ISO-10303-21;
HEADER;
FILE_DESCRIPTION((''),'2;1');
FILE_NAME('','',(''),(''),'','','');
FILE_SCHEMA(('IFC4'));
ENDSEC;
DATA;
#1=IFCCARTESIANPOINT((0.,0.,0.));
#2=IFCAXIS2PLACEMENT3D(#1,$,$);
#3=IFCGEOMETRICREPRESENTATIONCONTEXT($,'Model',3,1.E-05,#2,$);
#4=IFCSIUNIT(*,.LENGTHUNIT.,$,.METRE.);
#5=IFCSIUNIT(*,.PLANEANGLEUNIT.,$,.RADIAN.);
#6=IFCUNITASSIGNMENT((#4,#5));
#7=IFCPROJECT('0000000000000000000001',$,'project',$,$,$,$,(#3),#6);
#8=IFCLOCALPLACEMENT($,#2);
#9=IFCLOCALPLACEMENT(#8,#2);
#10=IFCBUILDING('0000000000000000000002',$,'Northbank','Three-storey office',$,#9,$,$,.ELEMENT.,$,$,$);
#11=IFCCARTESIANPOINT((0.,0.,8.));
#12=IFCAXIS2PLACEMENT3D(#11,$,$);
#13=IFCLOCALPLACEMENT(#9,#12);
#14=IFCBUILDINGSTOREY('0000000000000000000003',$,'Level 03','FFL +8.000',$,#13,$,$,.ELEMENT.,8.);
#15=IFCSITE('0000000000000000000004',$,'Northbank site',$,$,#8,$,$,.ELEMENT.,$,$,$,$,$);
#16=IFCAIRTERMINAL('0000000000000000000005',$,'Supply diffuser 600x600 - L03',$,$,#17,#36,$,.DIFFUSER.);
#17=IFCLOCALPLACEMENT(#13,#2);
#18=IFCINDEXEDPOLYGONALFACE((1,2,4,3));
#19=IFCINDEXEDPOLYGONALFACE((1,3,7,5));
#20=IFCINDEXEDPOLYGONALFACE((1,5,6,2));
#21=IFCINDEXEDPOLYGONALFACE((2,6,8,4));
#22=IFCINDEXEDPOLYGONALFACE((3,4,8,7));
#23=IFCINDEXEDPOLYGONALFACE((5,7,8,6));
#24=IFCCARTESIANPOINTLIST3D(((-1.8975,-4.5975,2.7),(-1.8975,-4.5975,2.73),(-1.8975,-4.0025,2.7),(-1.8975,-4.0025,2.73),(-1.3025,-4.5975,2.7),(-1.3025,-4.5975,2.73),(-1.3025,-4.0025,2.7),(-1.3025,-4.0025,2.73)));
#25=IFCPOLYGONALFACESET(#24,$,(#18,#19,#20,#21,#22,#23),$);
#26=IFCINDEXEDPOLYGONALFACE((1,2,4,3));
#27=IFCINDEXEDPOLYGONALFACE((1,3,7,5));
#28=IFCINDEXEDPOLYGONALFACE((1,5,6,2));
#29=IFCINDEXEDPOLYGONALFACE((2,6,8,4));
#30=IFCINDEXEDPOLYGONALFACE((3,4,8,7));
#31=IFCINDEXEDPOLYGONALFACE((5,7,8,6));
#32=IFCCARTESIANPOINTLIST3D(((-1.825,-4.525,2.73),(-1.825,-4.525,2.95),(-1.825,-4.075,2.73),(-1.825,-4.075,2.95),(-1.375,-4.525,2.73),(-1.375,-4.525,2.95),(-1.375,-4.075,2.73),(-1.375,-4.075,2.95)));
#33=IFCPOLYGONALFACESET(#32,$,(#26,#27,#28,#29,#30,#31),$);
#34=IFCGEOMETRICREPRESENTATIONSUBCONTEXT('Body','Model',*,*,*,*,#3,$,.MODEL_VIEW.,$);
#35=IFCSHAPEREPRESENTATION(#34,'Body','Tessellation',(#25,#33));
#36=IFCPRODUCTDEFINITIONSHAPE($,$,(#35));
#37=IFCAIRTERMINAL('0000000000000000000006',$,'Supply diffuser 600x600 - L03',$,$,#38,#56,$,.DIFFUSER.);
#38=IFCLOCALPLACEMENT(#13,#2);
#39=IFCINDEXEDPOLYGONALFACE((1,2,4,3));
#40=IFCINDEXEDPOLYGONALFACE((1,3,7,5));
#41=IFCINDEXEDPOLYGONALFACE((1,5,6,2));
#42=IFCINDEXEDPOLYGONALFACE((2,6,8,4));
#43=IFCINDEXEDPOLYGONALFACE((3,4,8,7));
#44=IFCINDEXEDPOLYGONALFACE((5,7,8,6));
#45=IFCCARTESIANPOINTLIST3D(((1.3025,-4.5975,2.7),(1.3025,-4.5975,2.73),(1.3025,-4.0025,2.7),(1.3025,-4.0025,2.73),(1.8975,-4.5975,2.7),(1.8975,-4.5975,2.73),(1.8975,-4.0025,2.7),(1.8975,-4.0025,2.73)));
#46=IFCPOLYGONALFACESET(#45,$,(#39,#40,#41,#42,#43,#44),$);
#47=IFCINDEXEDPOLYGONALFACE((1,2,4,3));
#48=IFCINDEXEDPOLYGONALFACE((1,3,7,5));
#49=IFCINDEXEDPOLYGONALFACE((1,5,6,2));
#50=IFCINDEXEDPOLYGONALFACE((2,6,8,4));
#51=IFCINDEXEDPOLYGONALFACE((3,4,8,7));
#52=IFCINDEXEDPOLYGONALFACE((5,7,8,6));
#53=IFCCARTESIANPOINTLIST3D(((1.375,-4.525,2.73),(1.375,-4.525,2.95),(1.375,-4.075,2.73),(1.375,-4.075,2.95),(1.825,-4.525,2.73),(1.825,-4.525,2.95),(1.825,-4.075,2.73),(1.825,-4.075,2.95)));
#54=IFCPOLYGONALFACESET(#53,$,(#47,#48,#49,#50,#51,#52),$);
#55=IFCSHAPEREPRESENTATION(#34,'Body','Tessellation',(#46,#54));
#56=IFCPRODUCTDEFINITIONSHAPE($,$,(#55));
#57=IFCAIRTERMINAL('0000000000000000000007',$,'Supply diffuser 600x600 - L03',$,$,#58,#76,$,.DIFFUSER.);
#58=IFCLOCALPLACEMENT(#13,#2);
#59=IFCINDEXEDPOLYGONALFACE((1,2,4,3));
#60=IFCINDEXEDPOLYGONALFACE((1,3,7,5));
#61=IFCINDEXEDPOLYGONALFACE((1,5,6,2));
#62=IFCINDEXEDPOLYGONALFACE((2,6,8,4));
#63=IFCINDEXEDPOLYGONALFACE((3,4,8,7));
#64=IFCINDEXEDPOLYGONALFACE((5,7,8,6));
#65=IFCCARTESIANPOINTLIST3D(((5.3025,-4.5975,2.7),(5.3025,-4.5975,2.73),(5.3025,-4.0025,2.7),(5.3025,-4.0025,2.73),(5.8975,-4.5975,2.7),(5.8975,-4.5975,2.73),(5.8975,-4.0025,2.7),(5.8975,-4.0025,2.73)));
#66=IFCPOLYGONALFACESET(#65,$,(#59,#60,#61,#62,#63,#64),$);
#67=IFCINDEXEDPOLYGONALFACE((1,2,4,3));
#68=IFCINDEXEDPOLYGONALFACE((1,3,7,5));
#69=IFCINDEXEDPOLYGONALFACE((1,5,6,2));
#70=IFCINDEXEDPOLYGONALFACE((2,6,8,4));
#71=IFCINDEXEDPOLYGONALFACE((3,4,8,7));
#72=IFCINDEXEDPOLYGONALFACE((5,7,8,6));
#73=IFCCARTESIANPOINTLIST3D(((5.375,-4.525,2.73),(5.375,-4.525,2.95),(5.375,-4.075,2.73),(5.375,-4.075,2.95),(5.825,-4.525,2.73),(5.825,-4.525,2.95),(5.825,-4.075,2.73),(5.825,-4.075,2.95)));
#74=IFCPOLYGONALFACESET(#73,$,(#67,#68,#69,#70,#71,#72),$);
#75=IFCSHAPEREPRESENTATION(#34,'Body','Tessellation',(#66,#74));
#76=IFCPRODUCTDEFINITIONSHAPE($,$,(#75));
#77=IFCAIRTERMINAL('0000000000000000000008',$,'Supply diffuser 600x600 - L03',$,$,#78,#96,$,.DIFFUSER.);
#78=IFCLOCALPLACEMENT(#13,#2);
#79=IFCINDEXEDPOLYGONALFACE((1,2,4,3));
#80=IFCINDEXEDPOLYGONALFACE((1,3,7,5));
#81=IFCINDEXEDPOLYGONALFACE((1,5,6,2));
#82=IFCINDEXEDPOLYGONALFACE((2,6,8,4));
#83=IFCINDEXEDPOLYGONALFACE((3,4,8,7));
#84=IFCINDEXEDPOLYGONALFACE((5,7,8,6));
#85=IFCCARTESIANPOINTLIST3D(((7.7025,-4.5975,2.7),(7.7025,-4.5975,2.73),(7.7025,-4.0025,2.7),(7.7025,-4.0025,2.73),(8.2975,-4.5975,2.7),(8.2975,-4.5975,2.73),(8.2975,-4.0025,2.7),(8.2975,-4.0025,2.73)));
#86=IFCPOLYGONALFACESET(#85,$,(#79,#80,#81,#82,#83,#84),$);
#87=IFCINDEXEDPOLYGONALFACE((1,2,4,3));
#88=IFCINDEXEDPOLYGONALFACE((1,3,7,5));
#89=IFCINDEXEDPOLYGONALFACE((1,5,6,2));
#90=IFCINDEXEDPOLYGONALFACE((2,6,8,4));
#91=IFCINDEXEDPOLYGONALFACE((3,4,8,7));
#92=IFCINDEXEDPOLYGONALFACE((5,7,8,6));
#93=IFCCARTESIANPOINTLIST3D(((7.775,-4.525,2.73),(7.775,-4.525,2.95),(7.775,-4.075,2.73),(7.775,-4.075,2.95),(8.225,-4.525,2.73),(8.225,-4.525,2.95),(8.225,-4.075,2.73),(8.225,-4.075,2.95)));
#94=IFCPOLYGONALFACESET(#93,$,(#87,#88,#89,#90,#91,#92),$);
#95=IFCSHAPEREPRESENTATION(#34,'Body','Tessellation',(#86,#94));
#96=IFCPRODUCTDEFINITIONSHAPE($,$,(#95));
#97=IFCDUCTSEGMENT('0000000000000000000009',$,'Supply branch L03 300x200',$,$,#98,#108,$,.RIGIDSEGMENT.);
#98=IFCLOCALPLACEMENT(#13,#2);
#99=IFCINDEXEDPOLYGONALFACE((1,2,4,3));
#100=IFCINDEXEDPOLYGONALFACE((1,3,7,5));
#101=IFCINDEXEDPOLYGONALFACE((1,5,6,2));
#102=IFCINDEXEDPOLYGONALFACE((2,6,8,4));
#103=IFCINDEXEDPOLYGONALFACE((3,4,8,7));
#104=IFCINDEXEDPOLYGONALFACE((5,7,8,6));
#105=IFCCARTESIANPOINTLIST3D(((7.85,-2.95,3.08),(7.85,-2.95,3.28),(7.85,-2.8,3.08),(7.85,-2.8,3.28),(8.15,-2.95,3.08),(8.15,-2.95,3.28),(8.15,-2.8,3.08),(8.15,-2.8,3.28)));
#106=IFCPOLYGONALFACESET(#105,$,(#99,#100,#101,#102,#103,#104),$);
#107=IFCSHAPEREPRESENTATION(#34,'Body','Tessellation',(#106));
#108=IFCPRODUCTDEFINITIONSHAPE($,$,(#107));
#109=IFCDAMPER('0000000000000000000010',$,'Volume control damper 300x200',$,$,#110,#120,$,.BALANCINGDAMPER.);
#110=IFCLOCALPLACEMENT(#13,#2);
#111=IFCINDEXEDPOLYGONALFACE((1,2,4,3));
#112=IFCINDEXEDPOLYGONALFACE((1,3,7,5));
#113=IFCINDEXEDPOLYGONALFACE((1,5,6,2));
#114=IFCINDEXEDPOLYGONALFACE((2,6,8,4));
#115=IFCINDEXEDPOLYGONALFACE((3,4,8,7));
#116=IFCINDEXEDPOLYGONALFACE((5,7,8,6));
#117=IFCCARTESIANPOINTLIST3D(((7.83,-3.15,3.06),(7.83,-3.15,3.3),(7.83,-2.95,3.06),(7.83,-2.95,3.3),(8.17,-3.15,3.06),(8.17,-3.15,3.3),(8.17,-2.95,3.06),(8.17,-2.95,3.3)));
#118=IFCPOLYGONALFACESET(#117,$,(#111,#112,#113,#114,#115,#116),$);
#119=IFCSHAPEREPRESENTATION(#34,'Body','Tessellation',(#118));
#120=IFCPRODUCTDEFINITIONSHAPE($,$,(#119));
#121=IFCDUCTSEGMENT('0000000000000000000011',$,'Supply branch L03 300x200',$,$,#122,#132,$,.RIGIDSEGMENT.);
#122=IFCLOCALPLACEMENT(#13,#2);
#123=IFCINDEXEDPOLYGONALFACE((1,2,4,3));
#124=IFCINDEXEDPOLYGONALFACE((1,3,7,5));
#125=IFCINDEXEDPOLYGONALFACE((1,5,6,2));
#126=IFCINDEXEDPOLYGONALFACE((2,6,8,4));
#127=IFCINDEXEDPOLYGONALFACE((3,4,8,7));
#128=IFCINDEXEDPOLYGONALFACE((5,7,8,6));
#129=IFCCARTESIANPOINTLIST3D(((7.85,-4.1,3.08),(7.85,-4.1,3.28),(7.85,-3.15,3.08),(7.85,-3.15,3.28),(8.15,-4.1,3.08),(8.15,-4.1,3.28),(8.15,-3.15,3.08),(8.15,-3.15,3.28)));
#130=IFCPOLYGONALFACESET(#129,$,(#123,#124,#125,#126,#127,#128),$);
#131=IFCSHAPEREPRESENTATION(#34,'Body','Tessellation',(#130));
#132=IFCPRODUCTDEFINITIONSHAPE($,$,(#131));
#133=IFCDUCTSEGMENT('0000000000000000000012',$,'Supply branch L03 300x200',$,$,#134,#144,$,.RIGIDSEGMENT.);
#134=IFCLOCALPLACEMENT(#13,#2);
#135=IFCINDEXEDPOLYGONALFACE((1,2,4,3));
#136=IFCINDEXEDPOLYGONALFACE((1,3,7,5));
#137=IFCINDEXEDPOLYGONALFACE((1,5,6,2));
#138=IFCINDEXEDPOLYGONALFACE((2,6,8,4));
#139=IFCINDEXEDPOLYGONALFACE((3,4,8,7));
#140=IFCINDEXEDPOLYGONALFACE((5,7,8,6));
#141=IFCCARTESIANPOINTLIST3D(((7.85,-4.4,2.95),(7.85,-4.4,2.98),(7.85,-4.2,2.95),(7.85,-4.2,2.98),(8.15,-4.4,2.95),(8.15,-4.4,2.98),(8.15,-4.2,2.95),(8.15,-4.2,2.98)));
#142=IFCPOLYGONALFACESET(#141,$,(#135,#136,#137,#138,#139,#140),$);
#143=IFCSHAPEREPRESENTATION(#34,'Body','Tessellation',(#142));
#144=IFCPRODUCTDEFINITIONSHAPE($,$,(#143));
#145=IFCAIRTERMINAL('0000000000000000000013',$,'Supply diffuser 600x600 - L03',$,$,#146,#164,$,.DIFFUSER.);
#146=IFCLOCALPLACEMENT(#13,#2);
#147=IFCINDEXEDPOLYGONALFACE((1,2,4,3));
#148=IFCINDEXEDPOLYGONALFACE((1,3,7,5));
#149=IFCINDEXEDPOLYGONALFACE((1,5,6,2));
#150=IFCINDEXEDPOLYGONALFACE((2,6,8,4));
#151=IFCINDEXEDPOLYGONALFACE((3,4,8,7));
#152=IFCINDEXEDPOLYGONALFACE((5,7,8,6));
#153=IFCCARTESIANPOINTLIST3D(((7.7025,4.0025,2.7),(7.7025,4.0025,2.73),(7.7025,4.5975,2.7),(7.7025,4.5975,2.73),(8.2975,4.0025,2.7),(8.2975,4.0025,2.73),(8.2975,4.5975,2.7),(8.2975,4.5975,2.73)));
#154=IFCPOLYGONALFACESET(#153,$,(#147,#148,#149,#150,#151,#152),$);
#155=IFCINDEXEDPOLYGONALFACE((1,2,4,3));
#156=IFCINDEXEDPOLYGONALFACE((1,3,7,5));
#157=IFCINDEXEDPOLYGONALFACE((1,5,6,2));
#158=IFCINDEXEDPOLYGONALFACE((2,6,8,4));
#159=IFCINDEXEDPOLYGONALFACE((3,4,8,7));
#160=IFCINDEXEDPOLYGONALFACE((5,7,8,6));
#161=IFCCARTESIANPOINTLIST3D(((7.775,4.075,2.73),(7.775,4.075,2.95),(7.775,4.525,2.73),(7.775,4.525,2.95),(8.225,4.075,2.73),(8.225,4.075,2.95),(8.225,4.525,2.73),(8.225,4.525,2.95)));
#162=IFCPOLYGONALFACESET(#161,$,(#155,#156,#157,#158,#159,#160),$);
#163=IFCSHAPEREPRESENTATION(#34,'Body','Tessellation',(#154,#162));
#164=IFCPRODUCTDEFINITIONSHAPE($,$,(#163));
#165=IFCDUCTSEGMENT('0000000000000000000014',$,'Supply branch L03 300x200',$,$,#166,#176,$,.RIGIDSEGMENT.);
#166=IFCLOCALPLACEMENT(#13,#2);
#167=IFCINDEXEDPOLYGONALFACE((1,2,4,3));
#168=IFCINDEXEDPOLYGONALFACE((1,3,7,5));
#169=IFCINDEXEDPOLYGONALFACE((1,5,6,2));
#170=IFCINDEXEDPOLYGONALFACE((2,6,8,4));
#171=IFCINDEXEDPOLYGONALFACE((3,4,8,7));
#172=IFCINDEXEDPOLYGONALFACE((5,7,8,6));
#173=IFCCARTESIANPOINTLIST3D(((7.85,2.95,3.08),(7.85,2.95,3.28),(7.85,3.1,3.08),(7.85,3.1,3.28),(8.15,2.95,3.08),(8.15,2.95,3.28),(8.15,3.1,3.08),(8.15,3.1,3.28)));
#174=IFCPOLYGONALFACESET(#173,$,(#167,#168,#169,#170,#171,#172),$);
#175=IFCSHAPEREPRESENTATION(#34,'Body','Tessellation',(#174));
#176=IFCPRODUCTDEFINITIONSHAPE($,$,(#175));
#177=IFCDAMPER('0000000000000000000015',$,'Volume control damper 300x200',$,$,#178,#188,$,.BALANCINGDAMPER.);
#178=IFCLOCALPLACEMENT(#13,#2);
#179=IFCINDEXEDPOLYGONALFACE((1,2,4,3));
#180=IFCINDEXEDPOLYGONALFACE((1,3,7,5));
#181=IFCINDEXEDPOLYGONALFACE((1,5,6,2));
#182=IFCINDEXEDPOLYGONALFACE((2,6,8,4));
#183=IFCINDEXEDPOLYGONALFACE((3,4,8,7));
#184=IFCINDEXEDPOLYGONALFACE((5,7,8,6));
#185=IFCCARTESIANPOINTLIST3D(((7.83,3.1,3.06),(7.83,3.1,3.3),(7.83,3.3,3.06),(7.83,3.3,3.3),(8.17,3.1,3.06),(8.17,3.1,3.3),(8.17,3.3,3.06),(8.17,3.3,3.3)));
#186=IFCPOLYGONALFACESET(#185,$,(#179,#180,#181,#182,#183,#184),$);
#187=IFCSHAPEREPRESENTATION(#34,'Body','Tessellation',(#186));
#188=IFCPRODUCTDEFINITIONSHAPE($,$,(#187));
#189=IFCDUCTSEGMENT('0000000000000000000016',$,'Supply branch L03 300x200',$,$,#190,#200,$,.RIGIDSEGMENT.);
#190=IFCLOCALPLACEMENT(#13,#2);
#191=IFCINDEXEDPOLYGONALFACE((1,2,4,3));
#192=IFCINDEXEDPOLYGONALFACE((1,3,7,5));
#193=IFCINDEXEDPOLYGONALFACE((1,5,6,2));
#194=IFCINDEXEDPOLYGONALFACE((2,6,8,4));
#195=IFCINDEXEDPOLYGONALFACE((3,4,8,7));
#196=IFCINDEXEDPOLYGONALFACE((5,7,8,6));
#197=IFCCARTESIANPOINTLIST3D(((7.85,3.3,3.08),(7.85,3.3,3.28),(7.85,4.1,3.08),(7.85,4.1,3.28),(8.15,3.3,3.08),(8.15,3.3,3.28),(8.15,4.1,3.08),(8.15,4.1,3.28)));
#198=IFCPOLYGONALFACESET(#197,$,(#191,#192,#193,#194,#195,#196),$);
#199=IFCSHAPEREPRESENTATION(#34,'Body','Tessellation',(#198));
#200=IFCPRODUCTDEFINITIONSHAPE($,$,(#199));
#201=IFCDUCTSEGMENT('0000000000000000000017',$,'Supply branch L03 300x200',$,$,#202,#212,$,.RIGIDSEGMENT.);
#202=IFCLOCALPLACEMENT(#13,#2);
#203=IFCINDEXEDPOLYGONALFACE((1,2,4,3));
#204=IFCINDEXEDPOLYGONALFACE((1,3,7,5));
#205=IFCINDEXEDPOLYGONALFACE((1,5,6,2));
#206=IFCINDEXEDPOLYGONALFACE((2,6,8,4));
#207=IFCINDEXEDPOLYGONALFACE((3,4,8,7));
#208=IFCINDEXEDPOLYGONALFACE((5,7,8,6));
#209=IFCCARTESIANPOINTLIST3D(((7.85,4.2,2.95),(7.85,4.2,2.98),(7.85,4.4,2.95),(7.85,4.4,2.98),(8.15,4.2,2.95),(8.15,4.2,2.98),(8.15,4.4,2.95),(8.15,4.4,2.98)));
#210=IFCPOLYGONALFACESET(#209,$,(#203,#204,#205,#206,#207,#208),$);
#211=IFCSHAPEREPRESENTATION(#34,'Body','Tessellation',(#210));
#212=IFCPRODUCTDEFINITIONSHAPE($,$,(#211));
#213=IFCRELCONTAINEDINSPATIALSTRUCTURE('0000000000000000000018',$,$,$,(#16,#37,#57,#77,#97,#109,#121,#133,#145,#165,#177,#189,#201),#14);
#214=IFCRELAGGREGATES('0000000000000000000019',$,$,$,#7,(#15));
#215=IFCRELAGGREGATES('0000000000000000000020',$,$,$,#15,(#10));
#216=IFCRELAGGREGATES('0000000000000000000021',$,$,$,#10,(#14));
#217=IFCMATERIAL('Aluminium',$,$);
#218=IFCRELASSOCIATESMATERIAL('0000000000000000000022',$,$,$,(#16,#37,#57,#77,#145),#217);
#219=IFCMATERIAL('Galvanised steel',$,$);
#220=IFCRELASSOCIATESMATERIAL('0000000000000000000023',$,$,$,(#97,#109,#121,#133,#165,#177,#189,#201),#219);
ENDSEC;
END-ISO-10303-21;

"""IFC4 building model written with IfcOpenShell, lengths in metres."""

from ifc_helpers import new_model, si_unit, frame, origin, place, context, subcontext, project, spatial, rectangle, extrude, material, element, save


model = new_model("IFC4")

# Units and contexts
model_context = context("Model", 3, precision=1e-05, world=origin())
body_context = subcontext(model_context, "Body", "Model", "MODEL_VIEW")
ifc_project = project(units=[si_unit("LENGTHUNIT", "METRE"), si_unit("PLANEANGLEUNIT", "RADIAN")], contexts=[model_context])

# Site, building, storey
site_placement = place(None, origin())
site = spatial("IfcSite", under=ifc_project, at=site_placement, Name="Northbank site", CompositionType="ELEMENT")
building_placement = place(site_placement, origin())
building = spatial("IfcBuilding", under=site, at=building_placement, Name="Northbank", Description="Three-storey office", CompositionType="ELEMENT")
storey_placement = place(building_placement, frame((0.0, 0.0, 8.0)))
storey = spatial("IfcBuildingStorey", under=building, at=storey_placement, Name="Level 03", Description="FFL +8.000", CompositionType="ELEMENT", Elevation=8.0)

# Shared definitions
ifc_material_1 = material(Name="Galvanised steel")

# Air terminal
ifc_material_2 = material(Name="Aluminium")
air_terminal_1_placement = place(storey_placement, frame((0.0, 0.0, -8.0)))
element("IfcAirTerminal", 1, at=air_terminal_1_placement, inside=storey, material=ifc_material_2, Name="Supply diffuser 600x600 - L03", PredefinedType="DIFFUSER", context=body_context, shape_type="SweptSolid", body=[
    extrude(rectangle(XDim=0.595, YDim=0.595), frame((-1.6, -4.3, 10.7)), (0.0, 0.0, 1.0), 0.03),
    extrude(rectangle(XDim=0.45, YDim=0.45), frame((-1.6, -4.3, 10.73)), (0.0, 0.0, 1.0), 0.22),
])

# Air terminal
air_terminal_2_placement = place(storey_placement, frame((0.0, 0.0, -8.0)))
element("IfcAirTerminal", 2, at=air_terminal_2_placement, inside=storey, material=ifc_material_2, Name="Supply diffuser 600x600 - L03", PredefinedType="DIFFUSER", context=body_context, shape_type="SweptSolid", body=[
    extrude(rectangle(XDim=0.595, YDim=0.595), frame((1.6, -4.3, 10.7)), (0.0, 0.0, 1.0), 0.03),
    extrude(rectangle(XDim=0.45, YDim=0.45), frame((1.6, -4.3, 10.73)), (0.0, 0.0, 1.0), 0.22),
])

# Air terminal
air_terminal_3_placement = place(storey_placement, frame((0.0, 0.0, -8.0)))
element("IfcAirTerminal", 3, at=air_terminal_3_placement, inside=storey, material=ifc_material_2, Name="Supply diffuser 600x600 - L03", PredefinedType="DIFFUSER", context=body_context, shape_type="SweptSolid", body=[
    extrude(rectangle(XDim=0.595, YDim=0.595), frame((5.6, -4.3, 10.7)), (0.0, 0.0, 1.0), 0.03),
    extrude(rectangle(XDim=0.45, YDim=0.45), frame((5.6, -4.3, 10.73)), (0.0, 0.0, 1.0), 0.22),
])

# Air terminal
air_terminal_4_placement = place(storey_placement, frame((0.0, 0.0, -8.0)))
element("IfcAirTerminal", 4, at=air_terminal_4_placement, inside=storey, material=ifc_material_2, Name="Supply diffuser 600x600 - L03", PredefinedType="DIFFUSER", context=body_context, shape_type="SweptSolid", body=[
    extrude(rectangle(XDim=0.595, YDim=0.595), frame((8.0, -4.3, 10.7)), (0.0, 0.0, 1.0), 0.03),
    extrude(rectangle(XDim=0.45, YDim=0.45), frame((8.0, -4.3, 10.73)), (0.0, 0.0, 1.0), 0.22),
])

# Duct segment
duct_segment_1_placement = place(storey_placement, frame((0.0, 0.0, -8.0)))
element("IfcDuctSegment", 5, at=duct_segment_1_placement, inside=storey, material=ifc_material_1, Name="Supply branch L03 300x200", PredefinedType="RIGIDSEGMENT", context=body_context, shape_type="SweptSolid", body=[
    extrude(rectangle(XDim=0.3, YDim=0.2), frame((8.0, -2.8, 11.18), z_axis=(0.0, -1.0, 0.0), x_axis=(1.0, 0.0, 0.0)), (0.0, 0.0, 1.0), 0.15),
])

# Damper
damper_1_placement = place(storey_placement, frame((0.0, 0.0, -8.0)))
element("IfcDamper", 6, at=damper_1_placement, inside=storey, material=ifc_material_1, Name="Volume control damper 300x200", PredefinedType="BALANCINGDAMPER", context=body_context, shape_type="SweptSolid", body=[
    extrude(rectangle(XDim=0.34, YDim=0.24), frame((8.0, -2.95, 11.18), z_axis=(0.0, -1.0, 0.0), x_axis=(1.0, 0.0, 0.0)), (0.0, 0.0, 1.0), 0.2),
])

# Duct segments
duct_segment_2_placement = place(storey_placement, frame((0.0, 0.0, -8.0)))
element("IfcDuctSegment", 7, at=duct_segment_2_placement, inside=storey, material=ifc_material_1, Name="Supply branch L03 300x200", PredefinedType="RIGIDSEGMENT", context=body_context, shape_type="SweptSolid", body=[
    extrude(rectangle(XDim=0.3, YDim=0.2), frame((8.0, -3.15, 11.18), z_axis=(0.0, -1.0, 0.0), x_axis=(1.0, 0.0, 0.0)), (0.0, 0.0, 1.0), 0.95),
])
duct_segment_3_placement = place(storey_placement, frame((0.0, 0.0, -8.0)))
element("IfcDuctSegment", 8, at=duct_segment_3_placement, inside=storey, material=ifc_material_1, Name="Supply branch L03 300x200", PredefinedType="RIGIDSEGMENT", context=body_context, shape_type="SweptSolid", body=[
    extrude(rectangle(XDim=0.3, YDim=0.2), frame((8.0, -4.3, 10.98), z_axis=(0.0, 0.0, -1.0), x_axis=(1.0, 0.0, 0.0)), (0.0, 0.0, 1.0), 0.03),
])

# Air terminal
air_terminal_5_placement = place(storey_placement, frame((0.0, 0.0, -8.0)))
element("IfcAirTerminal", 9, at=air_terminal_5_placement, inside=storey, material=ifc_material_2, Name="Supply diffuser 600x600 - L03", PredefinedType="DIFFUSER", context=body_context, shape_type="SweptSolid", body=[
    extrude(rectangle(XDim=0.595, YDim=0.595), frame((8.0, 4.3, 10.7)), (0.0, 0.0, 1.0), 0.03),
    extrude(rectangle(XDim=0.45, YDim=0.45), frame((8.0, 4.3, 10.73)), (0.0, 0.0, 1.0), 0.22),
])

# Duct segment
duct_segment_4_placement = place(storey_placement, frame((0.0, 0.0, -8.0)))
element("IfcDuctSegment", 10, at=duct_segment_4_placement, inside=storey, material=ifc_material_1, Name="Supply branch L03 300x200", PredefinedType="RIGIDSEGMENT", context=body_context, shape_type="SweptSolid", body=[
    extrude(rectangle(XDim=0.3, YDim=0.2), frame((8.0, 2.95, 11.18), z_axis=(0.0, 1.0, 0.0), x_axis=(-1.0, 0.0, 0.0)), (0.0, 0.0, 1.0), 0.15),
])

# Damper
damper_2_placement = place(storey_placement, frame((0.0, 0.0, -8.0)))
element("IfcDamper", 11, at=damper_2_placement, inside=storey, material=ifc_material_1, Name="Volume control damper 300x200", PredefinedType="BALANCINGDAMPER", context=body_context, shape_type="SweptSolid", body=[
    extrude(rectangle(XDim=0.34, YDim=0.24), frame((8.0, 3.1, 11.18), z_axis=(0.0, 1.0, 0.0), x_axis=(-1.0, 0.0, 0.0)), (0.0, 0.0, 1.0), 0.2),
])

# Duct segments
duct_segment_5_placement = place(storey_placement, frame((0.0, 0.0, -8.0)))
element("IfcDuctSegment", 12, at=duct_segment_5_placement, inside=storey, material=ifc_material_1, Name="Supply branch L03 300x200", PredefinedType="RIGIDSEGMENT", context=body_context, shape_type="SweptSolid", body=[
    extrude(rectangle(XDim=0.3, YDim=0.2), frame((8.0, 3.3, 11.18), z_axis=(0.0, 1.0, 0.0), x_axis=(-1.0, 0.0, 0.0)), (0.0, 0.0, 1.0), 0.8),
])
duct_segment_6_placement = place(storey_placement, frame((0.0, 0.0, -8.0)))
element("IfcDuctSegment", 13, at=duct_segment_6_placement, inside=storey, material=ifc_material_1, Name="Supply branch L03 300x200", PredefinedType="RIGIDSEGMENT", context=body_context, shape_type="SweptSolid", body=[
    extrude(rectangle(XDim=0.3, YDim=0.2), frame((8.0, 4.3, 10.98), z_axis=(0.0, 0.0, -1.0), x_axis=(-1.0, 0.0, 0.0)), (0.0, 0.0, 1.0), 0.03),
])

save(model, "model.ifc")
